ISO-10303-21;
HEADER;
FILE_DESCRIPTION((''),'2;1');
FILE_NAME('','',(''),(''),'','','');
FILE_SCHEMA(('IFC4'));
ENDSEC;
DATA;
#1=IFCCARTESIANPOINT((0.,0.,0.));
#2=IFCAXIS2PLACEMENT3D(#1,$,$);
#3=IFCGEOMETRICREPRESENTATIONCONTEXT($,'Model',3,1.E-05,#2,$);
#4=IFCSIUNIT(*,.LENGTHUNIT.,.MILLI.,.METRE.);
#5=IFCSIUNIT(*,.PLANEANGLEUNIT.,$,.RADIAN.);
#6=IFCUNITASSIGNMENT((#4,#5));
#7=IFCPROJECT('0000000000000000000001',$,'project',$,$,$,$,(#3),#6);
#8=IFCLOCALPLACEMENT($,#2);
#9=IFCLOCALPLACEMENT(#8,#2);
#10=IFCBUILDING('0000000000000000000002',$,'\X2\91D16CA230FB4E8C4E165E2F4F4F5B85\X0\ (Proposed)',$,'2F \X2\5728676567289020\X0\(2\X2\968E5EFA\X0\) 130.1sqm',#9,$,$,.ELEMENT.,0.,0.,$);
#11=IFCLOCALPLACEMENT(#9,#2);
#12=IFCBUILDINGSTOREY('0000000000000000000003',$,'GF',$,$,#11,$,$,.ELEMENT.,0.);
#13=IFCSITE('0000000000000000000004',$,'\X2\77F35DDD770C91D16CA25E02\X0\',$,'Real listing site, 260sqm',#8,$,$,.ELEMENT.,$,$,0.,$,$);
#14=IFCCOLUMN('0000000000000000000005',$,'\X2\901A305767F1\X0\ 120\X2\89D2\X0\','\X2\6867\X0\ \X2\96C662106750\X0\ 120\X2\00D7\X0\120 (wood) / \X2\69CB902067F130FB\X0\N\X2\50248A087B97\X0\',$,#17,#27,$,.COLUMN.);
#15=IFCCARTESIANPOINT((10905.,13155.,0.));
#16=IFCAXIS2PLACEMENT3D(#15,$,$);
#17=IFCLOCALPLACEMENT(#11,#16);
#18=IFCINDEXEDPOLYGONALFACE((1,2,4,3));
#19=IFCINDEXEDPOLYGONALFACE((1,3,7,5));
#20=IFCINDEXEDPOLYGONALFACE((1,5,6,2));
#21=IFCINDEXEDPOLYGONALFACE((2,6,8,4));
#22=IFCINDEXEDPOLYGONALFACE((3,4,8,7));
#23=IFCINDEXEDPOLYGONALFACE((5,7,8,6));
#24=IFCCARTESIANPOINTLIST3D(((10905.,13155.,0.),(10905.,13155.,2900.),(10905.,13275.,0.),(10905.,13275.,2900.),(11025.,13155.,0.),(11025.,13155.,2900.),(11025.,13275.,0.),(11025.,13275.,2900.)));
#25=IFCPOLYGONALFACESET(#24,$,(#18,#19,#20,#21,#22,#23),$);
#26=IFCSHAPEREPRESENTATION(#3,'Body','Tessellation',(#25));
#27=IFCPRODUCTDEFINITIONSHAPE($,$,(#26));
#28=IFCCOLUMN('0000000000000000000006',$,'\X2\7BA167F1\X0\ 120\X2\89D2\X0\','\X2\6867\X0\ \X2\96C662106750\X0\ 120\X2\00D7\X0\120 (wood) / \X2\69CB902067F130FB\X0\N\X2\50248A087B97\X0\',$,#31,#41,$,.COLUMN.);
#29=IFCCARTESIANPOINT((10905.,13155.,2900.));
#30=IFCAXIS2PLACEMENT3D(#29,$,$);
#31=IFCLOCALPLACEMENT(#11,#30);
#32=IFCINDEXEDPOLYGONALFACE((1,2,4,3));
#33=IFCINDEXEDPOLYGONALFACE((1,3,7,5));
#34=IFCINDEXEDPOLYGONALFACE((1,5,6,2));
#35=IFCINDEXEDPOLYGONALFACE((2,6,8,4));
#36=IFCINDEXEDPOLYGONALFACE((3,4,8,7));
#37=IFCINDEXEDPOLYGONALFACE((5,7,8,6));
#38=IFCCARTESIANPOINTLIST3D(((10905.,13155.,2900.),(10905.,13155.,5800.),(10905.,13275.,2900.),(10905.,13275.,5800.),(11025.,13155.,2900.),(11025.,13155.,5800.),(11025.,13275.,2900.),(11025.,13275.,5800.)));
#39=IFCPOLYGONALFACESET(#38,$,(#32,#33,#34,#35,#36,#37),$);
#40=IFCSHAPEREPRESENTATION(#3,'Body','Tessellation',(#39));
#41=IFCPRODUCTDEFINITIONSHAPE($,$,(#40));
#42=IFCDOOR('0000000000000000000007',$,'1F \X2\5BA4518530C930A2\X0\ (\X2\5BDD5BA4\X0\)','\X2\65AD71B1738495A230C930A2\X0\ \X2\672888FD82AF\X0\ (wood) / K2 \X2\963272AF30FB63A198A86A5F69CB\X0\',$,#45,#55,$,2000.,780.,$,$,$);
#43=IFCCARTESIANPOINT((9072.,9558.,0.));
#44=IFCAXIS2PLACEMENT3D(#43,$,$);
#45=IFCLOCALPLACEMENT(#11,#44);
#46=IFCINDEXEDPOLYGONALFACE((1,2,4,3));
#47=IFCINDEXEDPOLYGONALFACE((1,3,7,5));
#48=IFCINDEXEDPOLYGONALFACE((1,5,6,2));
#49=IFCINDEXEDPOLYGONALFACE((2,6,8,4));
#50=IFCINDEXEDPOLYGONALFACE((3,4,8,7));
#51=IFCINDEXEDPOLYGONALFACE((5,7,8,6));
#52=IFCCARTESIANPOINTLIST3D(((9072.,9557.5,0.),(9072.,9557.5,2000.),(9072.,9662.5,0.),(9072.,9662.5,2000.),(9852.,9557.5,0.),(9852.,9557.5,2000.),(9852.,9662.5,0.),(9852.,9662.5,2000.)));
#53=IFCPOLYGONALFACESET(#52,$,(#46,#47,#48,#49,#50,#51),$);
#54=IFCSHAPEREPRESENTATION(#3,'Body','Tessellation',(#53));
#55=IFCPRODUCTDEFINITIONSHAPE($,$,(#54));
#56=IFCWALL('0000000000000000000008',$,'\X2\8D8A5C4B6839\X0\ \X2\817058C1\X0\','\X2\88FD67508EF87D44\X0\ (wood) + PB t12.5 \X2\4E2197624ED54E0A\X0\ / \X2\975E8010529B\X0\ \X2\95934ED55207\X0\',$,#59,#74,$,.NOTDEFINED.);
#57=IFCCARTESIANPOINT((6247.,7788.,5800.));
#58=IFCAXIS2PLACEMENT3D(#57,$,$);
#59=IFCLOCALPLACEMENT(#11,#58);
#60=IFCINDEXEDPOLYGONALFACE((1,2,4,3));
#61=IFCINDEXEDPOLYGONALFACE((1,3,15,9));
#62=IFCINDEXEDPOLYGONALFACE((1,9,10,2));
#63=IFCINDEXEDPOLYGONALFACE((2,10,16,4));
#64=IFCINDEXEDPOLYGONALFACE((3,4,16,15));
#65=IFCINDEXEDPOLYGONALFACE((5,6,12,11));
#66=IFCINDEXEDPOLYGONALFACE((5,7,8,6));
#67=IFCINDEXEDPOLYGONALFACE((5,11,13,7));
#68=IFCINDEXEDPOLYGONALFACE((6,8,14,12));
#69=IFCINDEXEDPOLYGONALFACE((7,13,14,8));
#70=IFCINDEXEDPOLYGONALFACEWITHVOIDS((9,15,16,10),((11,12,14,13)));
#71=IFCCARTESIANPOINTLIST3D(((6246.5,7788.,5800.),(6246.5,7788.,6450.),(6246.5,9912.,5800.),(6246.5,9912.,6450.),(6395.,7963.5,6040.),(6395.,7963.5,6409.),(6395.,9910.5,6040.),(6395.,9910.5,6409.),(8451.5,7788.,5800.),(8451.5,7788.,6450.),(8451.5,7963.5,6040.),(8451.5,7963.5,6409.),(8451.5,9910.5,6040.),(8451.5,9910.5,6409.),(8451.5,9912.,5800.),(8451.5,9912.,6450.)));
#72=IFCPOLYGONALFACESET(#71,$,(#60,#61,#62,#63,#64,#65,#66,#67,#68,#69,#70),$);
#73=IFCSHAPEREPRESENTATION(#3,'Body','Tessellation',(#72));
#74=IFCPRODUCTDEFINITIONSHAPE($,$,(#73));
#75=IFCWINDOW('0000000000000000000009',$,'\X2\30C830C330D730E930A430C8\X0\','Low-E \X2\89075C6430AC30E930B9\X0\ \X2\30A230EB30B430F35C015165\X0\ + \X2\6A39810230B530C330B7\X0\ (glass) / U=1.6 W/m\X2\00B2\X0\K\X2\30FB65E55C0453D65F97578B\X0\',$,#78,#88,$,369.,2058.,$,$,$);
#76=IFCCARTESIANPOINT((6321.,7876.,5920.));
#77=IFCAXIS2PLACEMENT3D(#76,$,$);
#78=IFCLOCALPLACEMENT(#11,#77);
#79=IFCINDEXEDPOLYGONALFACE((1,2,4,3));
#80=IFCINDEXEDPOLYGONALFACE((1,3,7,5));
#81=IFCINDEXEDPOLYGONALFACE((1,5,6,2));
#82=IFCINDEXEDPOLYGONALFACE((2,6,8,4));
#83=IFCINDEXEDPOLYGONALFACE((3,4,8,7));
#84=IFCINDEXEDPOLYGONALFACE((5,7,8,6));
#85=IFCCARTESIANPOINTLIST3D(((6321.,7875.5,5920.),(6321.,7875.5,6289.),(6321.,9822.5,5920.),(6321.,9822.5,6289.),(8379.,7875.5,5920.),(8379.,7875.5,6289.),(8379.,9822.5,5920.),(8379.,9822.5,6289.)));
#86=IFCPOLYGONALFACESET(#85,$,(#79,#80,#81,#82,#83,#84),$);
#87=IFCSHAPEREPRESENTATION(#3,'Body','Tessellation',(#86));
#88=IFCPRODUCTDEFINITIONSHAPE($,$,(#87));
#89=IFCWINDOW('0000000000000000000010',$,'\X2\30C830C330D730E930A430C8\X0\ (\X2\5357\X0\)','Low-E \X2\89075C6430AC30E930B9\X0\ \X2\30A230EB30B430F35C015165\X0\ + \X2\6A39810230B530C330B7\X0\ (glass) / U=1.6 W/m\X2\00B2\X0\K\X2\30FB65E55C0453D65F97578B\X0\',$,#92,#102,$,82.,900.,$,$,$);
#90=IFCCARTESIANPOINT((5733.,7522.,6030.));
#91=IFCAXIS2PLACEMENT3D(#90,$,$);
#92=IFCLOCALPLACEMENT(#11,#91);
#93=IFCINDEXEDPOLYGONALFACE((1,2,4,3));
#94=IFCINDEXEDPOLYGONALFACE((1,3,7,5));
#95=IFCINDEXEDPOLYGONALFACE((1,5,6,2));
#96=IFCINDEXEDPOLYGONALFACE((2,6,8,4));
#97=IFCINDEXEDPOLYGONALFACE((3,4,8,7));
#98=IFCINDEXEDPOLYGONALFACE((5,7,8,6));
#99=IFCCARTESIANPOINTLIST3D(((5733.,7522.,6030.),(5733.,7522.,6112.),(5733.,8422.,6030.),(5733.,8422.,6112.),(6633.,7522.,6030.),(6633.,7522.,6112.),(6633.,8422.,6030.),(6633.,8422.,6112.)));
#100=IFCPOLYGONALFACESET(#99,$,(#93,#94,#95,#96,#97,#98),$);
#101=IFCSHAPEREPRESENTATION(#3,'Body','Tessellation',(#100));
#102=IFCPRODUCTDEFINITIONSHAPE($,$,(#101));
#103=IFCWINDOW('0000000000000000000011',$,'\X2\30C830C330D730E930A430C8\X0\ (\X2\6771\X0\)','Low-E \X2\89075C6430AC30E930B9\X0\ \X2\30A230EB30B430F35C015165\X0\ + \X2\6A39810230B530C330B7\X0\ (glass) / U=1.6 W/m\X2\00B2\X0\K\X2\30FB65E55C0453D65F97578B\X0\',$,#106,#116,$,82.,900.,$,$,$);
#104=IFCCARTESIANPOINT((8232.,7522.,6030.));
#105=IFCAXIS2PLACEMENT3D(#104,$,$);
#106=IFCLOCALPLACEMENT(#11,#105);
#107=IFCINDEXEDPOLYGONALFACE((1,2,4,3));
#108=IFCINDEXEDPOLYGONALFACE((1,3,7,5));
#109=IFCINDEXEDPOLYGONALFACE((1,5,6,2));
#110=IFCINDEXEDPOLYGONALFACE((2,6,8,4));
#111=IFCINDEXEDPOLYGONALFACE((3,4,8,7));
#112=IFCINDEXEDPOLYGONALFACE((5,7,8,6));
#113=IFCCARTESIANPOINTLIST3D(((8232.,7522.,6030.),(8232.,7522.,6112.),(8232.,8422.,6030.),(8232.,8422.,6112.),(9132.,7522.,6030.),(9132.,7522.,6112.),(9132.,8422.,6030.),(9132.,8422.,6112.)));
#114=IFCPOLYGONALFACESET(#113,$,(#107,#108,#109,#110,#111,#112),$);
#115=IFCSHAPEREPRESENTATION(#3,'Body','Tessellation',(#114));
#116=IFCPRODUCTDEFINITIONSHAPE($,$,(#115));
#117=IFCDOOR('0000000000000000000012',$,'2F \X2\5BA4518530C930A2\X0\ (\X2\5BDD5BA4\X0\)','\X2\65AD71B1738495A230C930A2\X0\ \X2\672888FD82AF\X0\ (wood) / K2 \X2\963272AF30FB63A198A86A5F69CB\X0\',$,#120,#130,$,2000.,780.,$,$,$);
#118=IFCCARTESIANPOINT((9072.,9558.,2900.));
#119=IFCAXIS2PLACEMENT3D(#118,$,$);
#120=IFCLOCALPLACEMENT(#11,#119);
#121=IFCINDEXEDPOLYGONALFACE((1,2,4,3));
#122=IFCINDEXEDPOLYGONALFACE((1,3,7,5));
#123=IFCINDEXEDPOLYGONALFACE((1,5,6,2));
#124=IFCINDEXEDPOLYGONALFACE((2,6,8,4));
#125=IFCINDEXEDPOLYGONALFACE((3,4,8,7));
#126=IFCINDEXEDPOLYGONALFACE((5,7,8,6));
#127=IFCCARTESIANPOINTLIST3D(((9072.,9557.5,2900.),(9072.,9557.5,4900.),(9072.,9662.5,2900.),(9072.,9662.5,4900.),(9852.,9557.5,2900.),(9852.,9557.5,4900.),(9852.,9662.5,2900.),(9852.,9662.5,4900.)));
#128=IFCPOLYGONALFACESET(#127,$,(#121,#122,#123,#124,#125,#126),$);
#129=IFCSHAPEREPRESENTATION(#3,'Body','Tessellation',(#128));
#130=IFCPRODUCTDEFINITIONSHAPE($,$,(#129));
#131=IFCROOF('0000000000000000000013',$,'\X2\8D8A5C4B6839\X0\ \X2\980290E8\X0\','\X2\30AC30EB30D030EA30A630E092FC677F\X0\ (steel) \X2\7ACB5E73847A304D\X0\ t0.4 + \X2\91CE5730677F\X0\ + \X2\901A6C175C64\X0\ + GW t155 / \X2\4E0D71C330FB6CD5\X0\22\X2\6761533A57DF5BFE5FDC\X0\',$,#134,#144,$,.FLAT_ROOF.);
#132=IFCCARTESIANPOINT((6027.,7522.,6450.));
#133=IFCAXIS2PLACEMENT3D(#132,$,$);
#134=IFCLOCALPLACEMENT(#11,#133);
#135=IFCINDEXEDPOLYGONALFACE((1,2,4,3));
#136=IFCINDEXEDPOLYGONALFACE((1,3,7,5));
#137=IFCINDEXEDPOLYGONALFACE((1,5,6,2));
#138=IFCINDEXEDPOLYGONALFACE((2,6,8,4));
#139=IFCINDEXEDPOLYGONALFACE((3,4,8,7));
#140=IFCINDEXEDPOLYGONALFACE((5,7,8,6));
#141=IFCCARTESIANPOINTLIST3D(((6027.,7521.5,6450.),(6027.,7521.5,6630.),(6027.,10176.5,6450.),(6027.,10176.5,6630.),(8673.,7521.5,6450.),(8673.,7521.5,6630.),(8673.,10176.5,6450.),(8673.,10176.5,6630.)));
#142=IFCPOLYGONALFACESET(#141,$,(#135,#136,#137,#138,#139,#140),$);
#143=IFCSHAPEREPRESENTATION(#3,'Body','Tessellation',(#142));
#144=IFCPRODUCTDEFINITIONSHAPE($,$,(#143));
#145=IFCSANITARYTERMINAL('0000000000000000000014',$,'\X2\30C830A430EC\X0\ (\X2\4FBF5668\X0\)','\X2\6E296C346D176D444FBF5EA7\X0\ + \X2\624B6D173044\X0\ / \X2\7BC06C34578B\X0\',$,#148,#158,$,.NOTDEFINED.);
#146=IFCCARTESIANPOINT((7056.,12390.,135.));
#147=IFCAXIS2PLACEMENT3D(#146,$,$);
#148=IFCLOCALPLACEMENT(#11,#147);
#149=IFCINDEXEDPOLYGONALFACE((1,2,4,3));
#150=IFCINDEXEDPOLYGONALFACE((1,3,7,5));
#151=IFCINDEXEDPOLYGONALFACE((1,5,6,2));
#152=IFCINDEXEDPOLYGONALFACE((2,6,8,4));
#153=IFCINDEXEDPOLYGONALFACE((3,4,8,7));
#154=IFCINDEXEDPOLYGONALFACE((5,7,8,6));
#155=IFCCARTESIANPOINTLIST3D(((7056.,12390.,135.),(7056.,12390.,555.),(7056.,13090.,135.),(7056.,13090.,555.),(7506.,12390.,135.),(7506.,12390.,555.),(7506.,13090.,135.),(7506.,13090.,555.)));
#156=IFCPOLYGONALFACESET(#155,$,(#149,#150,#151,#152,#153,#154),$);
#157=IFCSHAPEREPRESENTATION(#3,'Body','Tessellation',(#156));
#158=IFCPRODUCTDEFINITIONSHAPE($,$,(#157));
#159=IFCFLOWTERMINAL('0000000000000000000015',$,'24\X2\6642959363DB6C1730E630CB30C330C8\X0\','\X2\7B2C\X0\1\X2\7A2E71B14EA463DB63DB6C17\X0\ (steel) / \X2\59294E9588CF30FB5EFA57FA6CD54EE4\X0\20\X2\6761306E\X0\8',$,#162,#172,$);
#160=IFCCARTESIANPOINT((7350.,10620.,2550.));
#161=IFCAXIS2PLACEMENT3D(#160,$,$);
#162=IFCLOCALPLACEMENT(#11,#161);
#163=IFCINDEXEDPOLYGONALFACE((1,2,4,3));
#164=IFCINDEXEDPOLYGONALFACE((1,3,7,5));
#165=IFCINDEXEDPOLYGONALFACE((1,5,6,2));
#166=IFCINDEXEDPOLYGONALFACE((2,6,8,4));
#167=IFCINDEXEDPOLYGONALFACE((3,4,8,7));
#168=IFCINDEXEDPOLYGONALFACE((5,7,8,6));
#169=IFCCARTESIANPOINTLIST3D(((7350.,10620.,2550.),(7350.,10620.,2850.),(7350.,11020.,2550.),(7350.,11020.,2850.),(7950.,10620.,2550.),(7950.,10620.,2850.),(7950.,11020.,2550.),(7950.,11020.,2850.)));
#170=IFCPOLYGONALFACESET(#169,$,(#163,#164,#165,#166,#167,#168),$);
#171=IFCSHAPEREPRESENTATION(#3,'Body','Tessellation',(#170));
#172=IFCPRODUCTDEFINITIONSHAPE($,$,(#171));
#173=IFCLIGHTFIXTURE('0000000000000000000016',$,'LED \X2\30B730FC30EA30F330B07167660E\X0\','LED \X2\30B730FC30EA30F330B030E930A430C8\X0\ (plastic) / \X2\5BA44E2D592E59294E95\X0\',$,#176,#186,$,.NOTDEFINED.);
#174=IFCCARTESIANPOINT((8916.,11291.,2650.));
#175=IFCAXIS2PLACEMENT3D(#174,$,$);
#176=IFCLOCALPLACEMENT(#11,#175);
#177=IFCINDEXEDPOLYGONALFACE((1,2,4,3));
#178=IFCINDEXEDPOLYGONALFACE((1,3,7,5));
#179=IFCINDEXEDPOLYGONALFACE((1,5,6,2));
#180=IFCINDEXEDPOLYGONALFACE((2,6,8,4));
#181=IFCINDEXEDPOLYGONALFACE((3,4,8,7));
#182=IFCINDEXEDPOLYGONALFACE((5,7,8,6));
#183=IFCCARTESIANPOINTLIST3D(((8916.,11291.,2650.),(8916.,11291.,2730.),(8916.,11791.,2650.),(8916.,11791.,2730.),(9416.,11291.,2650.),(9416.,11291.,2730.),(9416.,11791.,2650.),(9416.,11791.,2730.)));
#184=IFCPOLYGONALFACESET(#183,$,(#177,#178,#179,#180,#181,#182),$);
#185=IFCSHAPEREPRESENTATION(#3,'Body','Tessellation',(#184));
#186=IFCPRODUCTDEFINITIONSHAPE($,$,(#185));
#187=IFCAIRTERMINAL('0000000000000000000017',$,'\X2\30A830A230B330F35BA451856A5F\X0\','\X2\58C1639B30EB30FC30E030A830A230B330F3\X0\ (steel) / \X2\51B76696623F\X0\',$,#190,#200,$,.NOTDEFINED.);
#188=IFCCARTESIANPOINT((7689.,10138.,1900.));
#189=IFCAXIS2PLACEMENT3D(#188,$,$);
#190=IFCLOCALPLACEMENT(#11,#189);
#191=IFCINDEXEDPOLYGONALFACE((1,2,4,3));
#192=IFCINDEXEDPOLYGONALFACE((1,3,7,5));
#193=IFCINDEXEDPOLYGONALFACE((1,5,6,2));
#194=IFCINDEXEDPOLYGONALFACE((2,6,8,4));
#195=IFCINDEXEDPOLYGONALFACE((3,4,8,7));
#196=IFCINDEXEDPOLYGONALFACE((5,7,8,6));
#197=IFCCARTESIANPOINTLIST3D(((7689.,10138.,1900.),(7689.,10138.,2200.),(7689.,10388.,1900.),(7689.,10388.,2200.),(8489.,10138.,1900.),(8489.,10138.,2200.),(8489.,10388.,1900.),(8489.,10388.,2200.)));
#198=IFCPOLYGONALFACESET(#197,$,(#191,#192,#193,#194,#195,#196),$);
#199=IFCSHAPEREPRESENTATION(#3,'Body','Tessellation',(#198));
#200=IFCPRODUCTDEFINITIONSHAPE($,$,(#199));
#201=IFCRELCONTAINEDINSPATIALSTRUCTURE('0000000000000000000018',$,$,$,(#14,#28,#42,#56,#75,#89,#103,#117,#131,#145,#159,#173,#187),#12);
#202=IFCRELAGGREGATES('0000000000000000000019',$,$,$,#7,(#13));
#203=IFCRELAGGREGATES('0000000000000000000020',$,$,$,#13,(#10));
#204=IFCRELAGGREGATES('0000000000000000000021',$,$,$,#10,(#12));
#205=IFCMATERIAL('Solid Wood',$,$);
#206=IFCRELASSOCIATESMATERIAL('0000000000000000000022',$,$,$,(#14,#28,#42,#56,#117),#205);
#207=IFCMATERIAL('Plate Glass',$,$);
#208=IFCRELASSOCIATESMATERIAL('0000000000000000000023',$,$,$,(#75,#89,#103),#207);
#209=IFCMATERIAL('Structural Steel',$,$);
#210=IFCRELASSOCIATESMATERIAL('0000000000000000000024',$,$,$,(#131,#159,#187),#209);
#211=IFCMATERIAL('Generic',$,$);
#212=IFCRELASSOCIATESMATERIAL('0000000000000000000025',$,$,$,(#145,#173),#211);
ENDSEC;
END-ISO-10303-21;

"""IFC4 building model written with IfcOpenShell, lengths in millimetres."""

from ifc_helpers import new_model, si_unit, frame, frame_2d, origin, place, context, project, spatial, rectangle, extrude, material, element, fill, save


model = new_model("IFC4")

# Units and contexts
model_context = context("Model", 3, precision=1e-05, world=origin())
ifc_project = project(units=[si_unit("LENGTHUNIT", "METRE", prefix="MILLI"), si_unit("PLANEANGLEUNIT", "RADIAN")], contexts=[model_context])

# Site, building, storey
site_placement = place(None, origin())
site = spatial("IfcSite", under=ifc_project, at=site_placement, Name="石川県金沢市", ObjectType="Real listing site, 260sqm", CompositionType="ELEMENT", RefElevation=0.0)
building_placement = place(site_placement, origin())
building = spatial("IfcBuilding", under=site, at=building_placement, Name="金沢・二世帯住宅 (Proposed)", ObjectType="2F 在来木造(2階建) 130.1sqm", CompositionType="ELEMENT", ElevationOfRefHeight=0.0, ElevationOfTerrain=0.0)
storey_placement = place(building_placement, origin())
storey = spatial("IfcBuildingStorey", under=building, at=storey_placement, Name="GF", CompositionType="ELEMENT", Elevation=0.0)

# Columns
ifc_material_1 = material(Name="Solid Wood")
column_1_placement = place(storey_placement, frame((10905.0, 13155.0, 0.0)))
element("IfcColumn", 1, at=column_1_placement, inside=storey, material=ifc_material_1, Name="通し柱 120角", Description="桧 集成材 120×120 (wood) / 構造柱・N値計算", PredefinedType="COLUMN", context=model_context, shape_type="SweptSolid", body=[
    extrude(rectangle(XDim=120.0, YDim=120.0, at=frame_2d((60.0, 60.0))), frame((10905.0, 13155.0, 0.0)), (0.0, 0.0, 1.0), 2900.0),
])
column_2_placement = place(storey_placement, frame((10905.0, 13155.0, 2900.0)))
element("IfcColumn", 2, at=column_2_placement, inside=storey, material=ifc_material_1, Name="管柱 120角", Description="桧 集成材 120×120 (wood) / 構造柱・N値計算", PredefinedType="COLUMN", context=model_context, shape_type="SweptSolid", body=[
    extrude(rectangle(XDim=120.0, YDim=120.0, at=frame_2d((60.0, 60.0))), frame((10905.0, 13155.0, 2900.0)), (0.0, 0.0, 1.0), 2900.0),
])

# Door
door_1_placement = place(storey_placement, frame((9072.0, 9558.0, 0.0)))
element("IfcDoor", 3, at=door_1_placement, inside=storey, material=ifc_material_1, Name="1F 室内ドア (寝室)", Description="断熱玄関ドア 木製芯 (wood) / K2 防犯・採風機構", OverallHeight=2000.0, OverallWidth=780.0, context=model_context, shape_type="SweptSolid", body=[
    extrude(rectangle(XDim=780.0, YDim=105.0, at=frame_2d((390.0, 52.0))), frame((9072.0, 9558.0, 0.0)), (0.0, 0.0, 1.0), 2000.0),
])

# Wall, openings, windows
wall_1_placement = place(storey_placement, frame((6247.0, 7788.0, 5800.0)))
wall_1 = element("IfcWall", 4, at=wall_1_placement, inside=storey, material=ifc_material_1, Name="越屋根 腰壁", Description="製材軸組 (wood) + PB t12.5 両面仕上 / 非耐力 間仕切", PredefinedType="NOTDEFINED", context=model_context, shape_type="SweptSolid", body=[
    extrude(rectangle(XDim=2205.0, YDim=2124.0, at=frame_2d((1102.0, 1062.0))), frame((6247.0, 7788.0, 5800.0)), (0.0, 0.0, 1.0), 650.0),
])
opening_1_placement = place(storey_placement, frame((6321.0, 7876.0, 5920.0)))
opening_1 = element("IfcOpeningElement", 5, at=opening_1_placement, cuts=wall_1, PredefinedType="NOTDEFINED", context=model_context, shape_type="SweptSolid", body=[
    extrude(rectangle(XDim=2058.0, YDim=1947.0, at=frame_2d((1029.0, 973.0))), frame((6321.0, 7876.0, 5920.0)), (0.0, 0.0, 1.0), 369.0),
])
opening_2_placement = place(storey_placement, frame((5733.0, 7522.0, 6030.0)))
opening_2 = element("IfcOpeningElement", 6, at=opening_2_placement, cuts=wall_1, PredefinedType="NOTDEFINED", context=model_context, shape_type="SweptSolid", body=[
    extrude(rectangle(XDim=900.0, YDim=900.0, at=frame_2d((450.0, 450.0))), frame((5733.0, 7522.0, 6030.0)), (0.0, 0.0, 1.0), 82.0),
])
opening_3_placement = place(storey_placement, frame((8232.0, 7522.0, 6030.0)))
opening_3 = element("IfcOpeningElement", 7, at=opening_3_placement, cuts=wall_1, PredefinedType="NOTDEFINED", context=model_context, shape_type="SweptSolid", body=[
    extrude(rectangle(XDim=900.0, YDim=900.0, at=frame_2d((450.0, 450.0))), frame((8232.0, 7522.0, 6030.0)), (0.0, 0.0, 1.0), 82.0),
])
ifc_material_2 = material(Name="Plate Glass")
window_1_placement = place(storey_placement, frame((6321.0, 7876.0, 5920.0)))
window_1 = element("IfcWindow", 8, at=window_1_placement, inside=storey, material=ifc_material_2, Name="トップライト", Description="Low-E 複層ガラス アルゴン封入 + 樹脂サッシ (glass) / U=1.6 W/m²K・日射取得型", OverallHeight=369.0, OverallWidth=2058.0, context=model_context, shape_type="SweptSolid", body=[
    extrude(rectangle(XDim=2058.0, YDim=1947.0, at=frame_2d((1029.0, 973.0))), frame((6321.0, 7876.0, 5920.0)), (0.0, 0.0, 1.0), 369.0),
])
fill(opening_1, window_1)
window_2_placement = place(storey_placement, frame((5733.0, 7522.0, 6030.0)))
window_2 = element("IfcWindow", 9, at=window_2_placement, inside=storey, material=ifc_material_2, Name="トップライト (南)", Description="Low-E 複層ガラス アルゴン封入 + 樹脂サッシ (glass) / U=1.6 W/m²K・日射取得型", OverallHeight=82.0, OverallWidth=900.0, context=model_context, shape_type="SweptSolid", body=[
    extrude(rectangle(XDim=900.0, YDim=900.0, at=frame_2d((450.0, 450.0))), frame((5733.0, 7522.0, 6030.0)), (0.0, 0.0, 1.0), 82.0),
])
fill(opening_2, window_2)
window_3_placement = place(storey_placement, frame((8232.0, 7522.0, 6030.0)))
window_3 = element("IfcWindow", 10, at=window_3_placement, inside=storey, material=ifc_material_2, Name="トップライト (東)", Description="Low-E 複層ガラス アルゴン封入 + 樹脂サッシ (glass) / U=1.6 W/m²K・日射取得型", OverallHeight=82.0, OverallWidth=900.0, context=model_context, shape_type="SweptSolid", body=[
    extrude(rectangle(XDim=900.0, YDim=900.0, at=frame_2d((450.0, 450.0))), frame((8232.0, 7522.0, 6030.0)), (0.0, 0.0, 1.0), 82.0),
])
fill(opening_3, window_3)

# Door
door_2_placement = place(storey_placement, frame((9072.0, 9558.0, 2900.0)))
element("IfcDoor", 11, at=door_2_placement, inside=storey, material=ifc_material_1, Name="2F 室内ドア (寝室)", Description="断熱玄関ドア 木製芯 (wood) / K2 防犯・採風機構", OverallHeight=2000.0, OverallWidth=780.0, context=model_context, shape_type="SweptSolid", body=[
    extrude(rectangle(XDim=780.0, YDim=105.0, at=frame_2d((390.0, 52.0))), frame((9072.0, 9558.0, 2900.0)), (0.0, 0.0, 1.0), 2000.0),
])

# Roof
ifc_material_3 = material(Name="Structural Steel")
roof_placement = place(storey_placement, frame((6027.0, 7522.0, 6450.0)))
element("IfcRoof", 12, at=roof_placement, inside=storey, material=ifc_material_3, Name="越屋根 頂部", Description="ガルバリウム鋼板 (steel) 立平葺き t0.4 + 野地板 + 通気層 + GW t155 / 不燃・法22条区域対応", PredefinedType="FLAT_ROOF", context=model_context, shape_type="SweptSolid", body=[
    extrude(rectangle(XDim=2646.0, YDim=2655.0, at=frame_2d((1323.0, 1327.0))), frame((6027.0, 7522.0, 6450.0)), (0.0, 0.0, 1.0), 180.0),
])

# Sanitary terminal
ifc_material_4 = material(Name="Generic")
sanitary_terminal_placement = place(storey_placement, frame((7056.0, 12390.0, 135.0)))
element("IfcSanitaryTerminal", 13, at=sanitary_terminal_placement, inside=storey, material=ifc_material_4, Name="トイレ (便器)", Description="温水洗浄便座 + 手洗い / 節水型", PredefinedType="NOTDEFINED", context=model_context, shape_type="SweptSolid", body=[
    extrude(rectangle(XDim=450.0, YDim=700.0, at=frame_2d((225.0, 350.0))), frame((7056.0, 12390.0, 135.0)), (0.0, 0.0, 1.0), 420.0),
])

# Flow terminal
flow_terminal_placement = place(storey_placement, frame((7350.0, 10620.0, 2550.0)))
element("IfcFlowTerminal", 14, at=flow_terminal_placement, inside=storey, material=ifc_material_3, Name="24時間換気ユニット", Description="第1種熱交換換気 (steel) / 天井裏・建基法令20条の8", context=model_context, shape_type="SweptSolid", body=[
    extrude(rectangle(XDim=600.0, YDim=400.0, at=frame_2d((300.0, 200.0))), frame((7350.0, 10620.0, 2550.0)), (0.0, 0.0, 1.0), 300.0),
])

# Light fixture
light_fixture_1_placement = place(storey_placement, frame((8916.0, 11291.0, 2650.0)))
element("IfcLightFixture", 15, at=light_fixture_1_placement, inside=storey, material=ifc_material_4, Name="LED シーリング照明", Description="LED シーリングライト (plastic) / 室中央天井", PredefinedType="NOTDEFINED", context=model_context, shape_type="SweptSolid", body=[
    extrude(rectangle(XDim=500.0, YDim=500.0, at=frame_2d((250.0, 250.0))), frame((8916.0, 11291.0, 2650.0)), (0.0, 0.0, 1.0), 80.0),
])

# Air terminal
air_terminal_placement = place(storey_placement, frame((7689.0, 10138.0, 1900.0)))
element("IfcAirTerminal", 16, at=air_terminal_placement, inside=storey, material=ifc_material_3, Name="エアコン室内機", Description="壁掛ルームエアコン (steel) / 冷暖房", PredefinedType="NOTDEFINED", context=model_context, shape_type="SweptSolid", body=[
    extrude(rectangle(XDim=800.0, YDim=250.0, at=frame_2d((400.0, 125.0))), frame((7689.0, 10138.0, 1900.0)), (0.0, 0.0, 1.0), 300.0),
])

save(model, "model.ifc")
